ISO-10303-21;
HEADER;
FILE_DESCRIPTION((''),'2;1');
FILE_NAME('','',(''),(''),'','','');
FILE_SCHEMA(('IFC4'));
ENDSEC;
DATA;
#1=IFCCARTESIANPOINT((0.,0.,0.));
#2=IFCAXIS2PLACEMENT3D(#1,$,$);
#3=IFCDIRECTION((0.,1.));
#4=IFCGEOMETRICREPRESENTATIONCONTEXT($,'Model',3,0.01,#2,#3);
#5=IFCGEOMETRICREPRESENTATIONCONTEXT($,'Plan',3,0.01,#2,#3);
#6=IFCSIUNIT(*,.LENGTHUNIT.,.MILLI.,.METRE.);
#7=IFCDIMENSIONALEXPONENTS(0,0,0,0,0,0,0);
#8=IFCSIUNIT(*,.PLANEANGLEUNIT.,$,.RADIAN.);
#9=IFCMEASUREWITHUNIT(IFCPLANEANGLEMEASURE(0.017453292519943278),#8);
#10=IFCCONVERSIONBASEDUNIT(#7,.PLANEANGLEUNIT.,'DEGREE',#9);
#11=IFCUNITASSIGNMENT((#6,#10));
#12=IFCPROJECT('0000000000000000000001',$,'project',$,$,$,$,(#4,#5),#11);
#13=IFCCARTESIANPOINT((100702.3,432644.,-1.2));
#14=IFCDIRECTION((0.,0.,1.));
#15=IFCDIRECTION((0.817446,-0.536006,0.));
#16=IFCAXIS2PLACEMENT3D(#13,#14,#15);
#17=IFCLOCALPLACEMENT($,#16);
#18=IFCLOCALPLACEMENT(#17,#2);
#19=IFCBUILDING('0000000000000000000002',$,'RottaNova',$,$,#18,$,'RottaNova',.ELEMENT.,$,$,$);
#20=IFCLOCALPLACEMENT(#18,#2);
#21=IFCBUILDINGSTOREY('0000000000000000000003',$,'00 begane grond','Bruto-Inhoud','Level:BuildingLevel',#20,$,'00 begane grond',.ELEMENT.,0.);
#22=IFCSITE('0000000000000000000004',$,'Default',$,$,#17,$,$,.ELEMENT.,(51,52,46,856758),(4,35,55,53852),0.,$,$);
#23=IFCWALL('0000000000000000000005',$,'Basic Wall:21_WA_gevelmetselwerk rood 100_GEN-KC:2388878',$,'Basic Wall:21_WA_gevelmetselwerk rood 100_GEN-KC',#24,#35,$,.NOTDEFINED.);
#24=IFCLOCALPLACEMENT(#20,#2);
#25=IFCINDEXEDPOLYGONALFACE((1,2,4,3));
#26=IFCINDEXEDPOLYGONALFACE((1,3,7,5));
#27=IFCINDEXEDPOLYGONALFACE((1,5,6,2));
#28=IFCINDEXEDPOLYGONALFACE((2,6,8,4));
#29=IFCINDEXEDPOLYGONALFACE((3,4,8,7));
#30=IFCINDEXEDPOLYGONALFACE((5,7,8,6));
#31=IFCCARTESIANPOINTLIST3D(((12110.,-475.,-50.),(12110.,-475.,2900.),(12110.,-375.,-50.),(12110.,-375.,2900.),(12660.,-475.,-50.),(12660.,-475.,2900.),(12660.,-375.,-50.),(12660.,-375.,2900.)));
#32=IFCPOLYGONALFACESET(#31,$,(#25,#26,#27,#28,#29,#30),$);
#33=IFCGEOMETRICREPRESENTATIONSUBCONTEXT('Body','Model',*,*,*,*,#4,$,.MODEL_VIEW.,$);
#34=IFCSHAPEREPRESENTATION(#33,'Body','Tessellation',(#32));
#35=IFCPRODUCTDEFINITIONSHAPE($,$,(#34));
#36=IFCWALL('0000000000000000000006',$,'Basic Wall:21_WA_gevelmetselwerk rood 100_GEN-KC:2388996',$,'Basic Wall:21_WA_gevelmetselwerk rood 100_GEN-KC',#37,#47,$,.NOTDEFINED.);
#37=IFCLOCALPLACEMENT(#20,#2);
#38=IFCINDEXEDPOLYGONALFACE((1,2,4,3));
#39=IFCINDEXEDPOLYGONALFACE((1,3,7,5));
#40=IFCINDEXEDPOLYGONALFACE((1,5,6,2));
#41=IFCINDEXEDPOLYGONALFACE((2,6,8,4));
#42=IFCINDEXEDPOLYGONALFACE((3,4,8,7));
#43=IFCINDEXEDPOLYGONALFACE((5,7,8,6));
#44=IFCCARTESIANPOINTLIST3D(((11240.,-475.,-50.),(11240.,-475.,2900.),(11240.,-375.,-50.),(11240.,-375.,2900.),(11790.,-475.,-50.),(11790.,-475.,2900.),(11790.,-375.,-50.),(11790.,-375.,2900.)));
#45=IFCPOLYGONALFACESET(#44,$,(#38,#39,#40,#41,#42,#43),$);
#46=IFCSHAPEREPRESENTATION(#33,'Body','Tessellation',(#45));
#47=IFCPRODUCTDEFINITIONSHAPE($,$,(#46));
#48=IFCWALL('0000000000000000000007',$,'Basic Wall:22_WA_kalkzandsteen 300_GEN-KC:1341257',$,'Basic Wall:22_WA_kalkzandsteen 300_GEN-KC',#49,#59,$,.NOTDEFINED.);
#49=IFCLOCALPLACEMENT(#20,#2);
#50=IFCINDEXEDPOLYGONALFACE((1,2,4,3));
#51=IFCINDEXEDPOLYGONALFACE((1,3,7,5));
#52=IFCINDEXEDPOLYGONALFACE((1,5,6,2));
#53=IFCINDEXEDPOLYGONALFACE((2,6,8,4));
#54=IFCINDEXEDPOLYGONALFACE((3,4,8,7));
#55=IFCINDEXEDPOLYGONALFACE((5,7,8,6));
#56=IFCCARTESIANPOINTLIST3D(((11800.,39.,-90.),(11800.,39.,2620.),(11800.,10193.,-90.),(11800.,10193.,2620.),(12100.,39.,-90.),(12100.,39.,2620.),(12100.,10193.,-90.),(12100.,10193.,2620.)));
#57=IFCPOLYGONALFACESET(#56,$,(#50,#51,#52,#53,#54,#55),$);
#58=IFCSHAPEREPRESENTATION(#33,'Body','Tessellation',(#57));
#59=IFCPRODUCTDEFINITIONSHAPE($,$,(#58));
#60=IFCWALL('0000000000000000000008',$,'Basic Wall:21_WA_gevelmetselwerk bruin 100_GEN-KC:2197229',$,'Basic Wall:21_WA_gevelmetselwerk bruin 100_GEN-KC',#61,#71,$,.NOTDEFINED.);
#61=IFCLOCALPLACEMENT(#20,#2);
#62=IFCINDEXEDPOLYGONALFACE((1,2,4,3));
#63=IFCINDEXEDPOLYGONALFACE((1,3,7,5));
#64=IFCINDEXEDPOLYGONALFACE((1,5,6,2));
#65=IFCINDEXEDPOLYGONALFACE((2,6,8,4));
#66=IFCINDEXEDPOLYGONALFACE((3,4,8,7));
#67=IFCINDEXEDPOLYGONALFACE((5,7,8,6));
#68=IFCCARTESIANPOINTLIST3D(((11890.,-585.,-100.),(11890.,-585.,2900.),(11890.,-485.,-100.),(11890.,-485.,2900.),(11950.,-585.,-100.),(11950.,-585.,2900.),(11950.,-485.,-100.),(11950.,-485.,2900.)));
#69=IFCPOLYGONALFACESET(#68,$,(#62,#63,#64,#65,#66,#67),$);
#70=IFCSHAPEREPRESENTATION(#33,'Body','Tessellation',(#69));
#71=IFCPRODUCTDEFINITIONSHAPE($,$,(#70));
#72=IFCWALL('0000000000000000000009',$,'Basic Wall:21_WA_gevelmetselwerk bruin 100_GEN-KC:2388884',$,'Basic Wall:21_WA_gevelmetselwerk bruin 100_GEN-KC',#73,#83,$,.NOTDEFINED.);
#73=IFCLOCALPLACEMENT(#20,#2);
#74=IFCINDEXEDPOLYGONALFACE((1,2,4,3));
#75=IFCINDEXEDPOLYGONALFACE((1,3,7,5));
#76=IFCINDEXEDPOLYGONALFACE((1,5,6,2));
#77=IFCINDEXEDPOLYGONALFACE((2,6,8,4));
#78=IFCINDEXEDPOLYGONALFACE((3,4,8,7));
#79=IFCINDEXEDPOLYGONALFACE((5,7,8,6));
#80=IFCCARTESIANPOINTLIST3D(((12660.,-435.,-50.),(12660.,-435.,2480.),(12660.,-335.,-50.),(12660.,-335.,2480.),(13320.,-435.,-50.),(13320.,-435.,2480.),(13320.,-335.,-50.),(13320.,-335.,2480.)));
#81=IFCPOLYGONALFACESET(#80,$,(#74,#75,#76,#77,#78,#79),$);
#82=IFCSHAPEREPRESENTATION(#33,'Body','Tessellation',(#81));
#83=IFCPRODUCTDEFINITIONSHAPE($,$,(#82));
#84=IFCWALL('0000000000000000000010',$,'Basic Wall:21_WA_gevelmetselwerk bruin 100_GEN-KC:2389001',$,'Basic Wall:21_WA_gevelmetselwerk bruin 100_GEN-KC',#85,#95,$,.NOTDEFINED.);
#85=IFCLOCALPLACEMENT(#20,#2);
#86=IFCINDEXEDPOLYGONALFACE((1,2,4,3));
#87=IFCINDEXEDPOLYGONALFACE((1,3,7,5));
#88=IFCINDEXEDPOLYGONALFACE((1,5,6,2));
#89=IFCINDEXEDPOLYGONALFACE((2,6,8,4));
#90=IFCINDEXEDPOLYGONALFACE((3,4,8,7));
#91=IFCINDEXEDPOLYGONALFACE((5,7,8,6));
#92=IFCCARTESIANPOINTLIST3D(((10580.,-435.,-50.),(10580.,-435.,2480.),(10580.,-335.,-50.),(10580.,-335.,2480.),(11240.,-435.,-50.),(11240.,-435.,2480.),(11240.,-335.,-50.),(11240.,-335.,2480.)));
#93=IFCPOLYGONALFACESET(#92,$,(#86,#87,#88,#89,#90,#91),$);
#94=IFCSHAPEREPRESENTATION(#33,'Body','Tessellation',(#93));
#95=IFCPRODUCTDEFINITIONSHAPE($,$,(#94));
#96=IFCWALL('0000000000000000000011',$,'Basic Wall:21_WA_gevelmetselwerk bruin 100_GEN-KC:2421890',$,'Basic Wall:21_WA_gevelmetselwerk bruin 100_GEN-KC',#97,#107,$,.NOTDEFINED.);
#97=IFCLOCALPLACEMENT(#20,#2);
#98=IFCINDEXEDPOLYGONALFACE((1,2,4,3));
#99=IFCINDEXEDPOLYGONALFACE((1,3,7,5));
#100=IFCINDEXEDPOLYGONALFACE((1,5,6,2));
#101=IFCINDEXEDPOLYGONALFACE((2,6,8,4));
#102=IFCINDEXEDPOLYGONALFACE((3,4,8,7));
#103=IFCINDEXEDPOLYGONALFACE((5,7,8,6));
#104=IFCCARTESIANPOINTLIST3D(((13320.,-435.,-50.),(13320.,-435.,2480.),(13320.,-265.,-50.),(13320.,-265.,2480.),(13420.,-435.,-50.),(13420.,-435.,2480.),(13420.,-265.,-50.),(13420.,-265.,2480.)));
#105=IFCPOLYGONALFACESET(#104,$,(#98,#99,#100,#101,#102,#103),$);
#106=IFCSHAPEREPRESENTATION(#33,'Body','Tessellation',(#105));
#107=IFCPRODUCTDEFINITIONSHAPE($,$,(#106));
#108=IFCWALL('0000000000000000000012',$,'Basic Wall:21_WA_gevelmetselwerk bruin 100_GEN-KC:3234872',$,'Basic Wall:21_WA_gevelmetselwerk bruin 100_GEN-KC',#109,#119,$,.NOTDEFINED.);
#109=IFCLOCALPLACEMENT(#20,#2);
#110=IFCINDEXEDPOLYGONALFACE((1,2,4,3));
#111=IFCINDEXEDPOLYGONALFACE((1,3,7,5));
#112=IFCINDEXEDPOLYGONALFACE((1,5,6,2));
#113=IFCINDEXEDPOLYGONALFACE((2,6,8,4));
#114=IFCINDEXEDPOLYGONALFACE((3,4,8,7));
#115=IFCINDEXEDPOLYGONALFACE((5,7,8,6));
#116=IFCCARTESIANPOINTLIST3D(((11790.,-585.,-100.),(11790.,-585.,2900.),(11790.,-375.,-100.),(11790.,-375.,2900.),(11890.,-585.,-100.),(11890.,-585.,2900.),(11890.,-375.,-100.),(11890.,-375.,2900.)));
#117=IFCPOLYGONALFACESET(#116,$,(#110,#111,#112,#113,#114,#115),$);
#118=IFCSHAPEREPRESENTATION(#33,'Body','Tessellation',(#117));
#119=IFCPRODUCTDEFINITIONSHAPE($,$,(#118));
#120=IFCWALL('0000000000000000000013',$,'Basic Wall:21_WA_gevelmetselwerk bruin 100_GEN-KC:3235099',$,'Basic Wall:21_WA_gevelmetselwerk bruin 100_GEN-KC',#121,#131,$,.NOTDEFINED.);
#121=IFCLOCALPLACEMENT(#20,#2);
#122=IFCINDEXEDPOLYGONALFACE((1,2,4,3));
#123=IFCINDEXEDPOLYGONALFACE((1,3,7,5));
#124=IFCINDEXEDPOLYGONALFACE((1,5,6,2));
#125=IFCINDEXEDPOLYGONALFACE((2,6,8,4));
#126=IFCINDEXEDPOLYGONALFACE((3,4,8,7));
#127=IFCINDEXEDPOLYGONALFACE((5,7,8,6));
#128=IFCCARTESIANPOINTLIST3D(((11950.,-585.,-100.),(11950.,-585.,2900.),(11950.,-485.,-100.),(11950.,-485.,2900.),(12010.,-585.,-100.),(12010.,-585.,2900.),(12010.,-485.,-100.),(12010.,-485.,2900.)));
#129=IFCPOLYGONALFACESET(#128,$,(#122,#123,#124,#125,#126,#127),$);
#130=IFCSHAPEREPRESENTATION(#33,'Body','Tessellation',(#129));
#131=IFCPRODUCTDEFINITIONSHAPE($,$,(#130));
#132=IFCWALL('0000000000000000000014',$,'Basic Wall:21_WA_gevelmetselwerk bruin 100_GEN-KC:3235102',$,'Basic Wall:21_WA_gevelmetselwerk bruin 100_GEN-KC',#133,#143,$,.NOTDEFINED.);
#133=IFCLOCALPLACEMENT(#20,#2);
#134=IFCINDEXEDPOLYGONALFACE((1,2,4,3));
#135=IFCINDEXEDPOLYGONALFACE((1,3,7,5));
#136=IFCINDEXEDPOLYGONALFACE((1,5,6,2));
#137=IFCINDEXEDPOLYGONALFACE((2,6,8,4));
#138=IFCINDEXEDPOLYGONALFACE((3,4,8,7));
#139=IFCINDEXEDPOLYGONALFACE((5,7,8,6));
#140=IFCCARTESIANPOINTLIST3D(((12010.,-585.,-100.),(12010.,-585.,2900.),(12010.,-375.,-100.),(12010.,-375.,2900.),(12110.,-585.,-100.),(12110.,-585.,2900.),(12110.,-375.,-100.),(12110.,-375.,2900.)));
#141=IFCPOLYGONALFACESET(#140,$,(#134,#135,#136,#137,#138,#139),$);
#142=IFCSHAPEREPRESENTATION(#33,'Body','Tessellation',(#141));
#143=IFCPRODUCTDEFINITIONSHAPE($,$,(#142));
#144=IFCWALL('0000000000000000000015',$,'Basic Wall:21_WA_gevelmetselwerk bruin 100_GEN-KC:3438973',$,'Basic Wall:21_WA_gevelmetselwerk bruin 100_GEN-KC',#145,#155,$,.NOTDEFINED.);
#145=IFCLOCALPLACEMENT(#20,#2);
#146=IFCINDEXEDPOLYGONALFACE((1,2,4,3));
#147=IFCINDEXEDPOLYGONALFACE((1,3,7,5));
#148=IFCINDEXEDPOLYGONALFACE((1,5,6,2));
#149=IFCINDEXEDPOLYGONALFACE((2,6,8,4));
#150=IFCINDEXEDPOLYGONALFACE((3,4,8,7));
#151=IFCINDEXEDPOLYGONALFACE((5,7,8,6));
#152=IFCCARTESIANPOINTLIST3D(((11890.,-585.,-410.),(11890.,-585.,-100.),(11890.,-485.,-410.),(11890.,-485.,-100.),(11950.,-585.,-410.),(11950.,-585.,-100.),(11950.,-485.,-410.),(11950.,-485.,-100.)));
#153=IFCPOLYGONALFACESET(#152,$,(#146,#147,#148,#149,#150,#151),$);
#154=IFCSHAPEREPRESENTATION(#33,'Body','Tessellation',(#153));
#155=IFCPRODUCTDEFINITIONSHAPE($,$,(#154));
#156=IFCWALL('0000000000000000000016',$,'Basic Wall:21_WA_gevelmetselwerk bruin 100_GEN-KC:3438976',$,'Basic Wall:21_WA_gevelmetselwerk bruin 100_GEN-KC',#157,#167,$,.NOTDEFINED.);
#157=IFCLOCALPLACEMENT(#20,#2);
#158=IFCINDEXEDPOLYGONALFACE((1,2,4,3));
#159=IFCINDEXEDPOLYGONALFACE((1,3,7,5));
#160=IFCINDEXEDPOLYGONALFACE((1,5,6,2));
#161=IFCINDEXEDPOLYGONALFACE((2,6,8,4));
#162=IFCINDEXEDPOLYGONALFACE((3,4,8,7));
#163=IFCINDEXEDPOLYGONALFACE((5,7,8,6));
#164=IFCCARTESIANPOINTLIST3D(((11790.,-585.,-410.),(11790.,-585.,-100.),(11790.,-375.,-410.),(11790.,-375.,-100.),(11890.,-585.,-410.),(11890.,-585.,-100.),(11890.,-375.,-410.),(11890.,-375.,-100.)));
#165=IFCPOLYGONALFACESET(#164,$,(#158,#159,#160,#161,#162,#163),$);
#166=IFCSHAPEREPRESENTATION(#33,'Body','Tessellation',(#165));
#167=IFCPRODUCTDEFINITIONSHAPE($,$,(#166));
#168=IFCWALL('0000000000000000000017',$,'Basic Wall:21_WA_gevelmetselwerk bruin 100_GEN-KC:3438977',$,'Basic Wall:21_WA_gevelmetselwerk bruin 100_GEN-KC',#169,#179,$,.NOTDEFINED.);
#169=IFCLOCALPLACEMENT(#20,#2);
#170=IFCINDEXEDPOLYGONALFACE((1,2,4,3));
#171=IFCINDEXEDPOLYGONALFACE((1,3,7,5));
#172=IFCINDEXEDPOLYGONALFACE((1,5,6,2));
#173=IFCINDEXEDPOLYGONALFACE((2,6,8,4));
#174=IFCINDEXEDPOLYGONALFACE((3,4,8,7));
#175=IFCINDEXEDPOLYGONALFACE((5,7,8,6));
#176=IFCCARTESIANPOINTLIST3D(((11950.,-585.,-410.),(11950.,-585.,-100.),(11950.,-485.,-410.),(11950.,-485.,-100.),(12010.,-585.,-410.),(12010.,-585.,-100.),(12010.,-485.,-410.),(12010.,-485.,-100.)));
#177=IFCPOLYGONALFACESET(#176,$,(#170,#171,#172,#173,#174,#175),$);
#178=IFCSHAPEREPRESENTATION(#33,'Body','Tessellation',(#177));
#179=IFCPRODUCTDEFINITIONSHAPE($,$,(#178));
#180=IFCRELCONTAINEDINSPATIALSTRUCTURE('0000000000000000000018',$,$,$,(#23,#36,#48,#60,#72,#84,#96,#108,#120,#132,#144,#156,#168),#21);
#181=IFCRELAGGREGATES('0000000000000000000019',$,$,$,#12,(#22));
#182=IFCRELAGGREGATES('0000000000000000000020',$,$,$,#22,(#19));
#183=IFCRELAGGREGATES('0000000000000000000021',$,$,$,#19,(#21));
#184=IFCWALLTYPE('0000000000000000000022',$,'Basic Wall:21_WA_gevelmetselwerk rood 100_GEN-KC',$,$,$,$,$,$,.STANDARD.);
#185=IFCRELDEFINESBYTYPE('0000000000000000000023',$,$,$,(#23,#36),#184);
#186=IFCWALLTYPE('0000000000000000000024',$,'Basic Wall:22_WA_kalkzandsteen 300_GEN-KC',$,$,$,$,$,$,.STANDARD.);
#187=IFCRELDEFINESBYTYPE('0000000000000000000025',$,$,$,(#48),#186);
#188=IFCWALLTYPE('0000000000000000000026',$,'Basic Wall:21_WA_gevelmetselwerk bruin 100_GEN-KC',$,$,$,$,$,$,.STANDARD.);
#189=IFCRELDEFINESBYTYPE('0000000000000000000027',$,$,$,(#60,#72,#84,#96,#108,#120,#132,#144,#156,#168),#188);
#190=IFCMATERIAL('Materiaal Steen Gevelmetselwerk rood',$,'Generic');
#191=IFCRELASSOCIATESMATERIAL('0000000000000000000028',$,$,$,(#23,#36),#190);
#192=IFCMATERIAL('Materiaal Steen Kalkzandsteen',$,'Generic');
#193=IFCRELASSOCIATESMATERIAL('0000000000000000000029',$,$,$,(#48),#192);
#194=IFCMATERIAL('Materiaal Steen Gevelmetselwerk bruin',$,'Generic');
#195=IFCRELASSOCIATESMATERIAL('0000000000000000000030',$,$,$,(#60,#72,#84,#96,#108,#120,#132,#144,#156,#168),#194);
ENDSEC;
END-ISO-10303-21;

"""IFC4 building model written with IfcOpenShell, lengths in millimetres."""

from ifc_helpers import new_model, entity, si_unit, converted_unit, direction, frame, origin, place, context, subcontext, project, spatial, indexed_curve, outline, extrude, material, type_object, element, save


model = new_model("IFC4")

# Units and contexts
model_context = context("Model", 3, precision=0.01, world=origin(), true_north=direction((0.0, 1.0)))
plan_context = context("Plan", 3, precision=0.01, world=origin(), true_north=direction((0.0, 1.0)))
body_context = subcontext(model_context, "Body", "Model", "MODEL_VIEW")
ifc_project = project(units=[si_unit("LENGTHUNIT", "METRE", prefix="MILLI"), converted_unit("PLANEANGLEUNIT", "DEGREE", entity("IfcPlaneAngleMeasure", 0.017453292519943278), si_unit("PLANEANGLEUNIT", "RADIAN"), dimensions=[0, 0, 0, 0, 0, 0, 0])], contexts=[model_context, plan_context])

# Site, building, storey
site_placement = place(None, frame((100702.3, 432644.0, -1.2), z_axis=(0.0, 0.0, 1.0), x_axis=(0.817446, -0.536006, 0.0)))
site = spatial("IfcSite", under=ifc_project, at=site_placement, Name="Default", CompositionType="ELEMENT", RefLatitude=(51, 52, 46, 856758), RefLongitude=(4, 35, 55, 53852), RefElevation=0.0)
building_placement = place(site_placement, origin())
building = spatial("IfcBuilding", under=site, at=building_placement, Name="RottaNova", LongName="RottaNova", CompositionType="ELEMENT")
storey_placement = place(building_placement, origin())
storey = spatial("IfcBuildingStorey", under=building, at=storey_placement, Name="00 begane grond", Description="Bruto-Inhoud", ObjectType="Level:BuildingLevel", LongName="00 begane grond", CompositionType="ELEMENT", Elevation=0.0)

# Walls
ifc_material_1 = material(Name="Materiaal Steen Gevelmetselwerk rood", Category="Generic")
wall_type_1 = type_object("IfcWallType", Name="Basic Wall:21_WA_gevelmetselwerk rood 100_GEN-KC", PredefinedType="STANDARD")
wall_1_placement = place(storey_placement, frame((12660.0, -425.0, -50.0), z_axis=(0.0, 0.0, 1.0), x_axis=(-1.0, 0.0, 0.0)))
element("IfcWall", 1, at=wall_1_placement, inside=storey, type_object=wall_type_1, material=ifc_material_1, Name="Basic Wall:21_WA_gevelmetselwerk rood 100_GEN-KC:2388878", ObjectType="Basic Wall:21_WA_gevelmetselwerk rood 100_GEN-KC", PredefinedType="NOTDEFINED", context=body_context, shape_type="SweptSolid", body=[
    extrude(outline(indexed_curve([(550.0, 50.0), (0.0, 50.0), (0.0, -50.0), (550.0, -50.0), (550.0, 50.0)], self_intersect=False)), origin(), (0.0, 0.0, 1.0), 2950.0),
])
wall_2_placement = place(storey_placement, frame((11240.0, -425.0, -50.0)))
element("IfcWall", 2, at=wall_2_placement, inside=storey, type_object=wall_type_1, material=ifc_material_1, Name="Basic Wall:21_WA_gevelmetselwerk rood 100_GEN-KC:2388996", ObjectType="Basic Wall:21_WA_gevelmetselwerk rood 100_GEN-KC", PredefinedType="NOTDEFINED", context=body_context, shape_type="SweptSolid", body=[
    extrude(outline(indexed_curve([(550.0, 50.0), (0.0, 50.0), (0.0, -50.0), (550.0, -50.0), (550.0, 50.0)], self_intersect=False)), origin(), (0.0, 0.0, 1.0), 2950.0),
])
ifc_material_2 = material(Name="Materiaal Steen Kalkzandsteen", Category="Generic")
wall_type_2 = type_object("IfcWallType", Name="Basic Wall:22_WA_kalkzandsteen 300_GEN-KC", PredefinedType="STANDARD")
wall_3_placement = place(storey_placement, frame((11950.0, 39.0, -90.0), z_axis=(0.0, 0.0, 1.0), x_axis=(0.0, 1.0, 0.0)))
element("IfcWall", 3, at=wall_3_placement, inside=storey, type_object=wall_type_2, material=ifc_material_2, Name="Basic Wall:22_WA_kalkzandsteen 300_GEN-KC:1341257", ObjectType="Basic Wall:22_WA_kalkzandsteen 300_GEN-KC", PredefinedType="NOTDEFINED", context=body_context, shape_type="SweptSolid", body=[
    extrude(outline(indexed_curve([(10154.0, 150.0), (0.0, 150.0), (0.0, -150.0), (10154.0, -150.0), (10154.0, 150.0)], self_intersect=False)), origin(), (0.0, 0.0, 1.0), 2710.0),
])
ifc_material_3 = material(Name="Materiaal Steen Gevelmetselwerk bruin", Category="Generic")
wall_type_3 = type_object("IfcWallType", Name="Basic Wall:21_WA_gevelmetselwerk bruin 100_GEN-KC", PredefinedType="STANDARD")
wall_4_placement = place(storey_placement, frame((11890.0, -535.0, -100.0)))
element("IfcWall", 4, at=wall_4_placement, inside=storey, type_object=wall_type_3, material=ifc_material_3, Name="Basic Wall:21_WA_gevelmetselwerk bruin 100_GEN-KC:2197229", ObjectType="Basic Wall:21_WA_gevelmetselwerk bruin 100_GEN-KC", PredefinedType="NOTDEFINED", context=body_context, shape_type="SweptSolid", body=[
    extrude(outline(indexed_curve([(60.0, 50.0), (0.0, 50.0), (0.0, -50.0), (60.0, -50.0), (60.0, 50.0)], self_intersect=False)), origin(), (0.0, 0.0, 1.0), 3000.0),
])
wall_5_placement = place(storey_placement, frame((12660.0, -385.0, -50.0)))
element("IfcWall", 5, at=wall_5_placement, inside=storey, type_object=wall_type_3, material=ifc_material_3, Name="Basic Wall:21_WA_gevelmetselwerk bruin 100_GEN-KC:2388884", ObjectType="Basic Wall:21_WA_gevelmetselwerk bruin 100_GEN-KC", PredefinedType="NOTDEFINED", context=body_context, shape_type="SweptSolid", body=[
    extrude(outline(indexed_curve([(660.0, 50.0), (0.0, 50.0), (0.0, -50.0), (660.0, -50.0), (660.0, 50.0)], self_intersect=False)), origin(), (0.0, 0.0, 1.0), 2530.0),
])
wall_6_placement = place(storey_placement, frame((11240.0, -385.0, -50.0), z_axis=(0.0, 0.0, 1.0), x_axis=(-1.0, 0.0, 0.0)))
element("IfcWall", 6, at=wall_6_placement, inside=storey, type_object=wall_type_3, material=ifc_material_3, Name="Basic Wall:21_WA_gevelmetselwerk bruin 100_GEN-KC:2389001", ObjectType="Basic Wall:21_WA_gevelmetselwerk bruin 100_GEN-KC", PredefinedType="NOTDEFINED", context=body_context, shape_type="SweptSolid", body=[
    extrude(outline(indexed_curve([(660.0, 50.0), (0.0, 50.0), (0.0, -50.0), (660.0, -50.0), (660.0, 50.0)], self_intersect=False)), origin(), (0.0, 0.0, 1.0), 2530.0),
])
wall_7_placement = place(storey_placement, frame((13370.0, -265.0, -50.0), z_axis=(0.0, 0.0, 1.0), x_axis=(0.0, -1.0, 0.0)))
element("IfcWall", 7, at=wall_7_placement, inside=storey, type_object=wall_type_3, material=ifc_material_3, Name="Basic Wall:21_WA_gevelmetselwerk bruin 100_GEN-KC:2421890", ObjectType="Basic Wall:21_WA_gevelmetselwerk bruin 100_GEN-KC", PredefinedType="NOTDEFINED", context=body_context, shape_type="SweptSolid", body=[
    extrude(outline(indexed_curve([(170.0, 50.0), (0.0, 50.0), (0.0, -50.0), (170.0, -50.0), (170.0, 50.0)], self_intersect=False)), origin(), (0.0, 0.0, 1.0), 2530.0),
])
wall_8_placement = place(storey_placement, frame((11840.0, -585.0, -100.0), z_axis=(0.0, 0.0, 1.0), x_axis=(0.0, 1.0, 0.0)))
element("IfcWall", 8, at=wall_8_placement, inside=storey, type_object=wall_type_3, material=ifc_material_3, Name="Basic Wall:21_WA_gevelmetselwerk bruin 100_GEN-KC:3234872", ObjectType="Basic Wall:21_WA_gevelmetselwerk bruin 100_GEN-KC", PredefinedType="NOTDEFINED", context=body_context, shape_type="SweptSolid", body=[
    extrude(outline(indexed_curve([(210.0, 50.0), (0.0, 50.0), (0.0, -50.0), (210.0, -50.0), (210.0, 50.0)], self_intersect=False)), origin(), (0.0, 0.0, 1.0), 3000.0),
])
wall_9_placement = place(storey_placement, frame((12010.0, -535.0, -100.0), z_axis=(0.0, 0.0, 1.0), x_axis=(-1.0, 0.0, 0.0)))
element("IfcWall", 9, at=wall_9_placement, inside=storey, type_object=wall_type_3, material=ifc_material_3, Name="Basic Wall:21_WA_gevelmetselwerk bruin 100_GEN-KC:3235099", ObjectType="Basic Wall:21_WA_gevelmetselwerk bruin 100_GEN-KC", PredefinedType="NOTDEFINED", context=body_context, shape_type="SweptSolid", body=[
    extrude(outline(indexed_curve([(60.0, 50.0), (0.0, 50.0), (0.0, -50.0), (60.0, -50.0), (60.0, 50.0)], self_intersect=False)), origin(), (0.0, 0.0, 1.0), 3000.0),
])
wall_10_placement = place(storey_placement, frame((12060.0, -585.0, -100.0), z_axis=(0.0, 0.0, 1.0), x_axis=(0.0, 1.0, 0.0)))
element("IfcWall", 10, at=wall_10_placement, inside=storey, type_object=wall_type_3, material=ifc_material_3, Name="Basic Wall:21_WA_gevelmetselwerk bruin 100_GEN-KC:3235102", ObjectType="Basic Wall:21_WA_gevelmetselwerk bruin 100_GEN-KC", PredefinedType="NOTDEFINED", context=body_context, shape_type="SweptSolid", body=[
    extrude(outline(indexed_curve([(210.0, 50.0), (0.0, 50.0), (0.0, -50.0), (210.0, -50.0), (210.0, 50.0)], self_intersect=False)), origin(), (0.0, 0.0, 1.0), 3000.0),
])
wall_11_placement = place(storey_placement, frame((11890.0, -535.0, -410.0)))
element("IfcWall", 11, at=wall_11_placement, inside=storey, type_object=wall_type_3, material=ifc_material_3, Name="Basic Wall:21_WA_gevelmetselwerk bruin 100_GEN-KC:3438973", ObjectType="Basic Wall:21_WA_gevelmetselwerk bruin 100_GEN-KC", PredefinedType="NOTDEFINED", context=body_context, shape_type="SweptSolid", body=[
    extrude(outline(indexed_curve([(60.0, 50.0), (0.0, 50.0), (0.0, -50.0), (60.0, -50.0), (60.0, 50.0)], self_intersect=False)), origin(), (0.0, 0.0, 1.0), 310.0),
])
wall_12_placement = place(storey_placement, frame((11840.0, -585.0, -410.0), z_axis=(0.0, 0.0, 1.0), x_axis=(0.0, 1.0, 0.0)))
element("IfcWall", 12, at=wall_12_placement, inside=storey, type_object=wall_type_3, material=ifc_material_3, Name="Basic Wall:21_WA_gevelmetselwerk bruin 100_GEN-KC:3438976", ObjectType="Basic Wall:21_WA_gevelmetselwerk bruin 100_GEN-KC", PredefinedType="NOTDEFINED", context=body_context, shape_type="SweptSolid", body=[
    extrude(outline(indexed_curve([(210.0, 50.0), (0.0, 50.0), (0.0, -50.0), (210.0, -50.0), (210.0, 50.0)], self_intersect=False)), origin(), (0.0, 0.0, 1.0), 310.0),
])
wall_13_placement = place(storey_placement, frame((12010.0, -535.0, -410.0), z_axis=(0.0, 0.0, 1.0), x_axis=(-1.0, 0.0, 0.0)))
element("IfcWall", 13, at=wall_13_placement, inside=storey, type_object=wall_type_3, material=ifc_material_3, Name="Basic Wall:21_WA_gevelmetselwerk bruin 100_GEN-KC:3438977", ObjectType="Basic Wall:21_WA_gevelmetselwerk bruin 100_GEN-KC", PredefinedType="NOTDEFINED", context=body_context, shape_type="SweptSolid", body=[
    extrude(outline(indexed_curve([(60.0, 50.0), (0.0, 50.0), (0.0, -50.0), (60.0, -50.0), (60.0, 50.0)], self_intersect=False)), origin(), (0.0, 0.0, 1.0), 310.0),
])

save(model, "model.ifc")
